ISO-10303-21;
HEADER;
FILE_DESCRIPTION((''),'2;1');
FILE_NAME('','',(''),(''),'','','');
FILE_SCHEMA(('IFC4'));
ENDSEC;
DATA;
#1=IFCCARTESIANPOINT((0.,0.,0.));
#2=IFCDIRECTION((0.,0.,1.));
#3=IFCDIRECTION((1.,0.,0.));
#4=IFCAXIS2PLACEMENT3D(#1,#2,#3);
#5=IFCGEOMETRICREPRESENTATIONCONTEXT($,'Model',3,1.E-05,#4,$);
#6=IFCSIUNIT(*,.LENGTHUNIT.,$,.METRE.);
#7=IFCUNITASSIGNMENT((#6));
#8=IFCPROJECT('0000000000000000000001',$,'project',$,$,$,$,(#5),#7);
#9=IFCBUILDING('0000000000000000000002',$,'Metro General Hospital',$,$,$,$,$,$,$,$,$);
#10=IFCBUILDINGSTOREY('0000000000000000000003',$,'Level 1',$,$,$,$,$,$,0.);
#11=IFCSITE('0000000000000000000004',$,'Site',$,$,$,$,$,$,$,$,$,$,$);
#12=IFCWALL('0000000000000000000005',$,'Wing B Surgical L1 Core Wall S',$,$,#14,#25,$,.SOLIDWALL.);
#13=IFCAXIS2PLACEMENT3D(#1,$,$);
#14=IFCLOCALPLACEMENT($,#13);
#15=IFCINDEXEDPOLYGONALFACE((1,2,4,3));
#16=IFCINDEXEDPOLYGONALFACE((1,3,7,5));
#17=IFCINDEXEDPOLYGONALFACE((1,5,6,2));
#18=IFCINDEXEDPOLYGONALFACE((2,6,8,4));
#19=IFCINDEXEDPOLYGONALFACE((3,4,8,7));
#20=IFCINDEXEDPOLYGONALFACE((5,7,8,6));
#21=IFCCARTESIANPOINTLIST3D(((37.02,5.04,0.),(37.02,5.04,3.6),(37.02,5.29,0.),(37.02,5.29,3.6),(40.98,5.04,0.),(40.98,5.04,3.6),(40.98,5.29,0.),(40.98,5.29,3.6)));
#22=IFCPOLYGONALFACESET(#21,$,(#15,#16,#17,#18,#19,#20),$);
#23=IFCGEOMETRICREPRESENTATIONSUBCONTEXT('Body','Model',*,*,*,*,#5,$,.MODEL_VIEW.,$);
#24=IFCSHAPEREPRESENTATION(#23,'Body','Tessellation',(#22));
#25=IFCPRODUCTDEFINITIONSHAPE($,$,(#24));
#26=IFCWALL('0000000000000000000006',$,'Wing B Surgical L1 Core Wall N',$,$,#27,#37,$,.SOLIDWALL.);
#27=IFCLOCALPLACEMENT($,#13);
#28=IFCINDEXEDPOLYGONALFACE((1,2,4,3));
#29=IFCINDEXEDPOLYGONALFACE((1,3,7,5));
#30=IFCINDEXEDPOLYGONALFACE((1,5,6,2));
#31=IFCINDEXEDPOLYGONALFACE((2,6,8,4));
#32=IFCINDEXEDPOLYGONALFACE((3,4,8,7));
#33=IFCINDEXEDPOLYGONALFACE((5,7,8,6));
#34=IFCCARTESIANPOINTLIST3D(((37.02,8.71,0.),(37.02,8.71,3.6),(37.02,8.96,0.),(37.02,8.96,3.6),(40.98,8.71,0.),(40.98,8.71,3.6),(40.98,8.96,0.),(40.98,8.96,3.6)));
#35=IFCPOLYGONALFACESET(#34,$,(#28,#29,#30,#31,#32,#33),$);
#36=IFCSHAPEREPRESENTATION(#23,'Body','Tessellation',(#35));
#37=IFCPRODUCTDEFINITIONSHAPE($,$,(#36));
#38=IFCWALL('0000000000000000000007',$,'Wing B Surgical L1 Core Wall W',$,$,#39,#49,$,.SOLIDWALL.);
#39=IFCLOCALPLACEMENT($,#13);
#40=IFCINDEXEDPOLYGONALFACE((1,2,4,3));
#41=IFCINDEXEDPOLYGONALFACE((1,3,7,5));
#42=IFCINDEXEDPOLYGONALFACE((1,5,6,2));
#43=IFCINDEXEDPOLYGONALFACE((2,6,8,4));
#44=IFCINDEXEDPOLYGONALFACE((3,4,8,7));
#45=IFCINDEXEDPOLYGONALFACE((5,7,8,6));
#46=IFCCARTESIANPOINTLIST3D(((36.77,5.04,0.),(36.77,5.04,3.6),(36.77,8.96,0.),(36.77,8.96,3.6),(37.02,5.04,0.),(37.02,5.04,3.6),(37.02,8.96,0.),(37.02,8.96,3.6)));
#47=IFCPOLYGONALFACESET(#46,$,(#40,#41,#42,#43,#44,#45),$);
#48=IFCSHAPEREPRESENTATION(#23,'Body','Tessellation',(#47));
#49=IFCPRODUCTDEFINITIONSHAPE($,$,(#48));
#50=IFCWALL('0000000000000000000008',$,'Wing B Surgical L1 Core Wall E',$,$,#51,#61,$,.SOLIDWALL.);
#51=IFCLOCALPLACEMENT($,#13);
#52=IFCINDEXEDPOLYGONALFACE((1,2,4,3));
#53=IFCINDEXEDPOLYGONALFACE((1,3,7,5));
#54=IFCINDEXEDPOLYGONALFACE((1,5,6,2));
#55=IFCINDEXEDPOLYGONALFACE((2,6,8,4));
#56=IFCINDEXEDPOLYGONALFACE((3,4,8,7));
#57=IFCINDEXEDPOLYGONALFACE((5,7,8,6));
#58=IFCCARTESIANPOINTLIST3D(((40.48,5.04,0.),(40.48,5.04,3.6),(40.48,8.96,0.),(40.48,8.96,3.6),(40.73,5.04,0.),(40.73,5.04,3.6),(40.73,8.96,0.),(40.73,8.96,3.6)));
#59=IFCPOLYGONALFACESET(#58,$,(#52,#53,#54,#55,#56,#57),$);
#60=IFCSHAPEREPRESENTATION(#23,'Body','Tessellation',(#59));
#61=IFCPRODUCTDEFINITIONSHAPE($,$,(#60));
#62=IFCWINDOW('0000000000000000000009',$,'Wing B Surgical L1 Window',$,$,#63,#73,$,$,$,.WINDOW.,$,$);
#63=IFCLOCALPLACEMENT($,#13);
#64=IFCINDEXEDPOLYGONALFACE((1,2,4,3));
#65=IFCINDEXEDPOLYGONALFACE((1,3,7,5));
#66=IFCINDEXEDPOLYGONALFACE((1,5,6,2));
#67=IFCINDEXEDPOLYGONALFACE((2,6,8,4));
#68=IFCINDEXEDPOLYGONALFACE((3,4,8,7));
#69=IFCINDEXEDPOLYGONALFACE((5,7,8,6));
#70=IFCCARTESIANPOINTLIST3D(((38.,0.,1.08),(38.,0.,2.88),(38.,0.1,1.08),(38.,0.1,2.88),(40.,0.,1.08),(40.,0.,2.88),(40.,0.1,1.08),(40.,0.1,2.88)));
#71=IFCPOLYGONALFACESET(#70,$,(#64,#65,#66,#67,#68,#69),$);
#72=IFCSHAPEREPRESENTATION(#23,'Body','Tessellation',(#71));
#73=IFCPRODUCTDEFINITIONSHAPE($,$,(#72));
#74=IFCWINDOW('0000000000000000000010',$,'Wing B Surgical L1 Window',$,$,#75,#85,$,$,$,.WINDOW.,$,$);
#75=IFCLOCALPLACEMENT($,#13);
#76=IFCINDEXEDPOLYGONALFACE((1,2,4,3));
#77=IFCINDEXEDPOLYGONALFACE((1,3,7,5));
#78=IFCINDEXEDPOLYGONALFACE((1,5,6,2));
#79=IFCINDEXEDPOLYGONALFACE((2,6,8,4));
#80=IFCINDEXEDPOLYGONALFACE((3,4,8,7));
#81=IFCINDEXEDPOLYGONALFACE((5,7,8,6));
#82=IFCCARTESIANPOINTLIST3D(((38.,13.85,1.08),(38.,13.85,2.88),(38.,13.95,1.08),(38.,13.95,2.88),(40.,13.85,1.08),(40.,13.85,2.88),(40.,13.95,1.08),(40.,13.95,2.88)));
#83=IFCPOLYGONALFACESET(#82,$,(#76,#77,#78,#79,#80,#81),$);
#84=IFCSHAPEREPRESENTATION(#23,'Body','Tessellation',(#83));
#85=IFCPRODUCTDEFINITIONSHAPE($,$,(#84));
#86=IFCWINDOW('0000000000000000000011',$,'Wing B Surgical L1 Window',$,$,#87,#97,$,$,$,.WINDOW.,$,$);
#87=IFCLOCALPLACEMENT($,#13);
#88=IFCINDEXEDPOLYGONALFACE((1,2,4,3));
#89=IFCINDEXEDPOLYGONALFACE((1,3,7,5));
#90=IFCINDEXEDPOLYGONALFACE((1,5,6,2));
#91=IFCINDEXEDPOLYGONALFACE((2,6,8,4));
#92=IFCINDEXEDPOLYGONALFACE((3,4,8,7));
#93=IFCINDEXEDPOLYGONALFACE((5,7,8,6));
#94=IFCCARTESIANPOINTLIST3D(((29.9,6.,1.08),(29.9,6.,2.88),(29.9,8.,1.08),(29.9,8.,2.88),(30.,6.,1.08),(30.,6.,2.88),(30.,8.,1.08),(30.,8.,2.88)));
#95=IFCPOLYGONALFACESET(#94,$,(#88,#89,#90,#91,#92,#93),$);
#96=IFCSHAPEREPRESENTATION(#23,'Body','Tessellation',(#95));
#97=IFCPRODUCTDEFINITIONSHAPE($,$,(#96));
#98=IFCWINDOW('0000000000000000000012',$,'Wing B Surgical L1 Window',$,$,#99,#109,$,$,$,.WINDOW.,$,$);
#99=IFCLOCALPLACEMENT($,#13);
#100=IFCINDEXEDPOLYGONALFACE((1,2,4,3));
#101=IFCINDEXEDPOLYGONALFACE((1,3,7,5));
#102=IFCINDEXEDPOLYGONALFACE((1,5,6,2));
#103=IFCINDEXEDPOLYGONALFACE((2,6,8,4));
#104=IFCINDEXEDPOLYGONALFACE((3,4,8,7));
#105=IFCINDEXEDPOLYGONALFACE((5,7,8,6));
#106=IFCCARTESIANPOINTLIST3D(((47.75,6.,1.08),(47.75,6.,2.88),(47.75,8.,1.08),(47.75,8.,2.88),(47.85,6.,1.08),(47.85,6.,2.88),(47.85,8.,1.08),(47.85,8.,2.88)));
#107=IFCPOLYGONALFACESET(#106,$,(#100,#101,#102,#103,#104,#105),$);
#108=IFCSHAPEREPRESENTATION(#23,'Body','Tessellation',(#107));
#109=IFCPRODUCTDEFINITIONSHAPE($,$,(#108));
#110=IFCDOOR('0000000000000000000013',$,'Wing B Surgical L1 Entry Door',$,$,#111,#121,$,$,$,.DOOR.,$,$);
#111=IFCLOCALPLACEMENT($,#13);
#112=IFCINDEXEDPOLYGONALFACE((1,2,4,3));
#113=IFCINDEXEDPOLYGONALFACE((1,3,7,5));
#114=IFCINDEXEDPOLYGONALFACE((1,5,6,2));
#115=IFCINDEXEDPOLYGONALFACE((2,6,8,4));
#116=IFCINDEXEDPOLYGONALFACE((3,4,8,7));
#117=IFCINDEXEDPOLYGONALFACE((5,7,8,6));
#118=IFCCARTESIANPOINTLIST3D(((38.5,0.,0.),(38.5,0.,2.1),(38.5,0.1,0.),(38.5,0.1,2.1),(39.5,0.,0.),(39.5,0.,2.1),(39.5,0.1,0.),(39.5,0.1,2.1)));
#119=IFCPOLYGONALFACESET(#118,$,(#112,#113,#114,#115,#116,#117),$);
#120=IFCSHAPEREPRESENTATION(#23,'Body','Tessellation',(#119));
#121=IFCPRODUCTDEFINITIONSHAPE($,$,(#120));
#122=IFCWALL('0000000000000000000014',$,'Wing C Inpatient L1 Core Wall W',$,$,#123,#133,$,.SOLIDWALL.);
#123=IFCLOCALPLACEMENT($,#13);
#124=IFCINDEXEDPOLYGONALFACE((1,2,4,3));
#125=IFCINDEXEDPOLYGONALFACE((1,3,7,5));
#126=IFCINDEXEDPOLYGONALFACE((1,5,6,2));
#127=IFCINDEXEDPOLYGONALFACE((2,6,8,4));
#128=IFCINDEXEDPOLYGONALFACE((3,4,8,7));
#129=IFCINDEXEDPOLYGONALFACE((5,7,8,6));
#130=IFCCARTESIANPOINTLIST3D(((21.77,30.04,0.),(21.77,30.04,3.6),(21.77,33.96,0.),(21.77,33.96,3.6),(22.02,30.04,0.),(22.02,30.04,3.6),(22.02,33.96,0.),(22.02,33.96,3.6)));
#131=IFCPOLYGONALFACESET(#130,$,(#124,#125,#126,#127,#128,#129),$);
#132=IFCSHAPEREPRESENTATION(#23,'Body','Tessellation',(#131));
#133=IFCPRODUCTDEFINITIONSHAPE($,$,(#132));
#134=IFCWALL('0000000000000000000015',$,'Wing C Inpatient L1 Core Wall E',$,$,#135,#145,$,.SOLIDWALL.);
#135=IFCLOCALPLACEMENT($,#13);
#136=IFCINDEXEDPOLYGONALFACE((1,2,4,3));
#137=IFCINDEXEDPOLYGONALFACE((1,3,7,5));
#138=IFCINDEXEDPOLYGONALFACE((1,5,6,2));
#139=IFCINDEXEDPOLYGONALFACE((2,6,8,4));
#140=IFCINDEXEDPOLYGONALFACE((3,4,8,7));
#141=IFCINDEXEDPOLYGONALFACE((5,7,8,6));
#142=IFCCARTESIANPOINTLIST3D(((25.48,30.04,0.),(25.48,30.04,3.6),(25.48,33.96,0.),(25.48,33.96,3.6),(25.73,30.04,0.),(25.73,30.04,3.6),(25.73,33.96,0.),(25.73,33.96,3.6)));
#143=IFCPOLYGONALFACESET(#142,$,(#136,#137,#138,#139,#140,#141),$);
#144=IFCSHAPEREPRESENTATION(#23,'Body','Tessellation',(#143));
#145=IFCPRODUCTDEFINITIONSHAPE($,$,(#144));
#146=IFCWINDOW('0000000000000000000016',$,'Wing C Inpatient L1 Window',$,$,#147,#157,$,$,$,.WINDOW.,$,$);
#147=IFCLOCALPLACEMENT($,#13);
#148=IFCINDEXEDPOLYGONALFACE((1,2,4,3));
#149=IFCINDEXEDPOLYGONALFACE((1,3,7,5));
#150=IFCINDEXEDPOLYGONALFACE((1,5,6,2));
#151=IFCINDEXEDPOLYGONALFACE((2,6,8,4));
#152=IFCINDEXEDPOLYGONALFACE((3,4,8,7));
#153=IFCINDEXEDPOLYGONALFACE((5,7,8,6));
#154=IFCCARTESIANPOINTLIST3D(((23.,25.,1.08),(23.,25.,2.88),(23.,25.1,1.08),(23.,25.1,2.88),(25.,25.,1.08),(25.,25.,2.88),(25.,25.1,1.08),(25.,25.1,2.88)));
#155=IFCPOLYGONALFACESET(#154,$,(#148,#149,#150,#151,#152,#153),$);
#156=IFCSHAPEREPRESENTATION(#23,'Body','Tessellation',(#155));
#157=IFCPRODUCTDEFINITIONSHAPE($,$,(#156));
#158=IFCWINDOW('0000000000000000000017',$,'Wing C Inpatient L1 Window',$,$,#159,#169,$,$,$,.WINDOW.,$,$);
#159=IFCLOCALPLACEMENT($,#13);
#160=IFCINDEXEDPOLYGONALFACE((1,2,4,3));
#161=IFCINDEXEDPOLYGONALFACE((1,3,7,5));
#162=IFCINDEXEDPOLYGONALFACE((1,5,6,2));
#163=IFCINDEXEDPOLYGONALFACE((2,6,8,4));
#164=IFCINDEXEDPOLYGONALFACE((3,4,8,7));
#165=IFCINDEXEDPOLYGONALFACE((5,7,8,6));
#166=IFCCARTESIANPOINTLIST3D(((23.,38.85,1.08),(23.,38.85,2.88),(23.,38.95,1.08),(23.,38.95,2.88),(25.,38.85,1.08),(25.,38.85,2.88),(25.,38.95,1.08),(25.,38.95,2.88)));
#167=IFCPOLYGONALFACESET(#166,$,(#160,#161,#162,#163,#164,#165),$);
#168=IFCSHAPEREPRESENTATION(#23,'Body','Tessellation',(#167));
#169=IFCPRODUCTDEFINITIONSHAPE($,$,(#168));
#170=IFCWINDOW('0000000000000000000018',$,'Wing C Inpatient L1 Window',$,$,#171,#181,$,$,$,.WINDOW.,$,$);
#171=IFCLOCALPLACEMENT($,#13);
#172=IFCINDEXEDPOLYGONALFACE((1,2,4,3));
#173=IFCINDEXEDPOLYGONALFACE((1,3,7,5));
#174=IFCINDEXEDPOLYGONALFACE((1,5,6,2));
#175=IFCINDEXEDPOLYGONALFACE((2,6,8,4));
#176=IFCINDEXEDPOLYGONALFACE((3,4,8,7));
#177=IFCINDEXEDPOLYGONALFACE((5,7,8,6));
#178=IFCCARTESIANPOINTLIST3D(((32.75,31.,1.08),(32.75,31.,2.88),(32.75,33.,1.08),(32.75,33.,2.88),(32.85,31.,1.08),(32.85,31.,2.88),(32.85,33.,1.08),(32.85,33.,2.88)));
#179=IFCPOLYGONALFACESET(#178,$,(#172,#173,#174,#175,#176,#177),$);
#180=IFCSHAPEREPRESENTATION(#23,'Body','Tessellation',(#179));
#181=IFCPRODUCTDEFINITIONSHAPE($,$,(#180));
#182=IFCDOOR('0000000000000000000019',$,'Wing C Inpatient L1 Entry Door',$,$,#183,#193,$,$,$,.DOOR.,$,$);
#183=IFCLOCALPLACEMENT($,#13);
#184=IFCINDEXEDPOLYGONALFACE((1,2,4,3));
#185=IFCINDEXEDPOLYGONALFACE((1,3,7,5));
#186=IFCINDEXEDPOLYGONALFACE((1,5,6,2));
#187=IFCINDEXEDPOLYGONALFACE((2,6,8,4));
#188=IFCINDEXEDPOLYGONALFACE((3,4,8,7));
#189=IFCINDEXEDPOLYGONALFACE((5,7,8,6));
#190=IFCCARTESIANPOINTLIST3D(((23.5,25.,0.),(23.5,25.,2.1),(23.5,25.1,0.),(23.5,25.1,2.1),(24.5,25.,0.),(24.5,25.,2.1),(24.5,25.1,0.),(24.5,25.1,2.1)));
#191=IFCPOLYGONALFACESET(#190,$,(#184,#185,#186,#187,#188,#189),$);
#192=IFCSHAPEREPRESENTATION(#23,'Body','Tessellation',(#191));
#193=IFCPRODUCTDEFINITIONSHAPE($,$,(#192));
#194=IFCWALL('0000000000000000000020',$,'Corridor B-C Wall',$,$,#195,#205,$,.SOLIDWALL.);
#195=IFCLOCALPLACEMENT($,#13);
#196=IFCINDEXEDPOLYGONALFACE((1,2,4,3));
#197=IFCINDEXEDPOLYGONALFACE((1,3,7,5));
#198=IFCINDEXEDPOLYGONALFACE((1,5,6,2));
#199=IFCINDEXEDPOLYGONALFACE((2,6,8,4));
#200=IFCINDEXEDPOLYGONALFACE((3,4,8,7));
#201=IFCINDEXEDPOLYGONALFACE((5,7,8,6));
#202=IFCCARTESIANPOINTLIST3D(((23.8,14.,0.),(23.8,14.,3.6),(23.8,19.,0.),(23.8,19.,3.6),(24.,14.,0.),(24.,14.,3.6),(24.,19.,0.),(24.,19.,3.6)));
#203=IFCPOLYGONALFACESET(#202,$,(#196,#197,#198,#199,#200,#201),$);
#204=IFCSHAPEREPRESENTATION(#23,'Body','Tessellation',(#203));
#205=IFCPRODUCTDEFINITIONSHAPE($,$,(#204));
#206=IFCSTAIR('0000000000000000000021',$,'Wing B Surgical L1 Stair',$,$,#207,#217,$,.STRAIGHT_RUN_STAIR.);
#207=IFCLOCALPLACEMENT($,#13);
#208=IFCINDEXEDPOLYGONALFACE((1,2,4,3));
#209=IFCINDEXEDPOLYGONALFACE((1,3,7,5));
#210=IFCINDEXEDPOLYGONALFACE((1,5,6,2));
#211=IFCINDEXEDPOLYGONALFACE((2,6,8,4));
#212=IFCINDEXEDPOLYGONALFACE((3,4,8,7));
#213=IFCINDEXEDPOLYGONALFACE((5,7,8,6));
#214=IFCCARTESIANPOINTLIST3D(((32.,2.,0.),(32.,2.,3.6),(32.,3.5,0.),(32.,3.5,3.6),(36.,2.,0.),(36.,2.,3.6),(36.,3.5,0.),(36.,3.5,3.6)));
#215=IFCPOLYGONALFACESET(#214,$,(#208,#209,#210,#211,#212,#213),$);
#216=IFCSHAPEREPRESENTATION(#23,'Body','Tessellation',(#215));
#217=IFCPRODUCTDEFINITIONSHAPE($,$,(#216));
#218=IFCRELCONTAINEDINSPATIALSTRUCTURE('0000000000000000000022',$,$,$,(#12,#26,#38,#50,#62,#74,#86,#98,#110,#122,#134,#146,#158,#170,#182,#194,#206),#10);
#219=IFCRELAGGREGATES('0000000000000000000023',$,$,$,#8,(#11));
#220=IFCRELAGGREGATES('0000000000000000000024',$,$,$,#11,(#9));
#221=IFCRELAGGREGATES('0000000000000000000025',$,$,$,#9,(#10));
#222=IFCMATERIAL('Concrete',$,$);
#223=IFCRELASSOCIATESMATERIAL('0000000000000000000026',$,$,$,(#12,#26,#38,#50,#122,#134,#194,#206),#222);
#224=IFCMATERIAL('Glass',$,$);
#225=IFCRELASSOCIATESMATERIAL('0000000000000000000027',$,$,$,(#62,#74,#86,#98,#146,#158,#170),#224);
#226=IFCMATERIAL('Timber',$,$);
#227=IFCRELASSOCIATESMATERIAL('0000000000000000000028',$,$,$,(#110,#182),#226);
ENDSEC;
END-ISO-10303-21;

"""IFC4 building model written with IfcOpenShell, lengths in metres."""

from ifc_helpers import new_model, si_unit, frame, origin_with_axes, place, context, subcontext, project, spatial, line, indexed_curve, outline, extrude, material, element, save


model = new_model("IFC4")

# Units and contexts
model_context = context("Model", 3, precision=1e-05, world=origin_with_axes())
body_context = subcontext(model_context, "Body", "Model", "MODEL_VIEW")
ifc_project = project(units=[si_unit("LENGTHUNIT", "METRE")], contexts=[model_context])

# Site, building, storey
site = spatial("IfcSite", under=ifc_project, Name="Site")
building = spatial("IfcBuilding", under=site, Name="Metro General Hospital")
storey = spatial("IfcBuildingStorey", under=building, Name="Level 1", Elevation=0.0)

# Shared definitions
ifc_material_1 = material(Name="Concrete")

# Walls
for number, where, z_axis, x_axis, name in (
    (1, (37.02, 5.04, 0.0), (0.0, 0.0, 1.0), (1.0, 0.0, 0.0), "Wing B Surgical L1 Core Wall S"),
    (2, (37.02, 8.71, 0.0), (0.0, 0.0, 1.0), (1.0, 0.0, 0.0), "Wing B Surgical L1 Core Wall N"),
):
    element("IfcWall", number, at=place(None, frame(where, z_axis=z_axis, x_axis=x_axis)), inside=storey, material=ifc_material_1, Name=name, PredefinedType="SOLIDWALL", context=body_context, shape_type="SweptSolid", body=[
        extrude(outline(indexed_curve([(0.0, 0.0), (3.96, 0.0), (3.96, 0.25), (0.0, 0.25)], segments=[line(1, 2, 3, 4, 1)])), origin_with_axes(), (0.0, 0.0, 1.0), 3.6),
    ])
for number, where, z_axis, x_axis, name in (
    (3, (37.02, 5.04, 0.0), (0.0, 0.0, 1.0), (0.0, 1.0, 0.0), "Wing B Surgical L1 Core Wall W"),
    (4, (40.73, 5.04, 0.0), (0.0, 0.0, 1.0), (0.0, 1.0, 0.0), "Wing B Surgical L1 Core Wall E"),
):
    element("IfcWall", number, at=place(None, frame(where, z_axis=z_axis, x_axis=x_axis)), inside=storey, material=ifc_material_1, Name=name, PredefinedType="SOLIDWALL", context=body_context, shape_type="SweptSolid", body=[
        extrude(outline(indexed_curve([(0.0, 0.0), (3.92, 0.0), (3.92, 0.25), (0.0, 0.25)], segments=[line(1, 2, 3, 4, 1)])), origin_with_axes(), (0.0, 0.0, 1.0), 3.6),
    ])

# Windows
ifc_material_2 = material(Name="Glass")
for number, where, z_axis, x_axis, name in (
    (5, (38.0, 0.0, 1.08), (0.0, 0.0, 1.0), (1.0, 0.0, 0.0), "Wing B Surgical L1 Window"),
    (6, (38.0, 13.85, 1.08), (0.0, 0.0, 1.0), (1.0, 0.0, 0.0), "Wing B Surgical L1 Window"),
    (7, (30.0, 6.0, 1.08), (0.0, 0.0, 1.0), (0.0, 1.0, 0.0), "Wing B Surgical L1 Window"),
    (8, (47.85, 6.0, 1.08), (0.0, 0.0, 1.0), (0.0, 1.0, 0.0), "Wing B Surgical L1 Window"),
):
    element("IfcWindow", number, at=place(None, frame(where, z_axis=z_axis, x_axis=x_axis)), inside=storey, material=ifc_material_2, Name=name, PredefinedType="WINDOW", context=body_context, shape_type="SweptSolid", body=[
        extrude(outline(indexed_curve([(0.0, 0.0), (2.0, 0.0), (2.0, 0.1), (0.0, 0.1)], segments=[line(1, 2, 3, 4, 1)])), origin_with_axes(), (0.0, 0.0, 1.0), 1.8),
    ])

# Door
ifc_material_3 = material(Name="Timber")
door_1_placement = place(None, frame((38.5, 0.0, 0.0), z_axis=(0.0, 0.0, 1.0), x_axis=(1.0, 0.0, 0.0)))
element("IfcDoor", 9, at=door_1_placement, inside=storey, material=ifc_material_3, Name="Wing B Surgical L1 Entry Door", PredefinedType="DOOR", context=body_context, shape_type="SweptSolid", body=[
    extrude(outline(indexed_curve([(0.0, 0.0), (1.0, 0.0), (1.0, 0.1), (0.0, 0.1)], segments=[line(1, 2, 3, 4, 1)])), origin_with_axes(), (0.0, 0.0, 1.0), 2.1),
])

# Walls
for number, where, z_axis, x_axis, name in (
    (10, (22.02, 30.04, 0.0), (0.0, 0.0, 1.0), (0.0, 1.0, 0.0), "Wing C Inpatient L1 Core Wall W"),
    (11, (25.73, 30.04, 0.0), (0.0, 0.0, 1.0), (0.0, 1.0, 0.0), "Wing C Inpatient L1 Core Wall E"),
):
    element("IfcWall", number, at=place(None, frame(where, z_axis=z_axis, x_axis=x_axis)), inside=storey, material=ifc_material_1, Name=name, PredefinedType="SOLIDWALL", context=body_context, shape_type="SweptSolid", body=[
        extrude(outline(indexed_curve([(0.0, 0.0), (3.92, 0.0), (3.92, 0.25), (0.0, 0.25)], segments=[line(1, 2, 3, 4, 1)])), origin_with_axes(), (0.0, 0.0, 1.0), 3.6),
    ])

# Windows
for number, where, z_axis, x_axis, name in (
    (12, (23.0, 25.0, 1.08), (0.0, 0.0, 1.0), (1.0, 0.0, 0.0), "Wing C Inpatient L1 Window"),
    (13, (23.0, 38.85, 1.08), (0.0, 0.0, 1.0), (1.0, 0.0, 0.0), "Wing C Inpatient L1 Window"),
    (14, (32.85, 31.0, 1.08), (0.0, 0.0, 1.0), (0.0, 1.0, 0.0), "Wing C Inpatient L1 Window"),
):
    element("IfcWindow", number, at=place(None, frame(where, z_axis=z_axis, x_axis=x_axis)), inside=storey, material=ifc_material_2, Name=name, PredefinedType="WINDOW", context=body_context, shape_type="SweptSolid", body=[
        extrude(outline(indexed_curve([(0.0, 0.0), (2.0, 0.0), (2.0, 0.1), (0.0, 0.1)], segments=[line(1, 2, 3, 4, 1)])), origin_with_axes(), (0.0, 0.0, 1.0), 1.8),
    ])

# Door
door_2_placement = place(None, frame((23.5, 25.0, 0.0), z_axis=(0.0, 0.0, 1.0), x_axis=(1.0, 0.0, 0.0)))
element("IfcDoor", 15, at=door_2_placement, inside=storey, material=ifc_material_3, Name="Wing C Inpatient L1 Entry Door", PredefinedType="DOOR", context=body_context, shape_type="SweptSolid", body=[
    extrude(outline(indexed_curve([(0.0, 0.0), (1.0, 0.0), (1.0, 0.1), (0.0, 0.1)], segments=[line(1, 2, 3, 4, 1)])), origin_with_axes(), (0.0, 0.0, 1.0), 2.1),
])

# Wall
wall_placement = place(None, frame((24.0, 14.0, 0.0), z_axis=(0.0, 0.0, 1.0), x_axis=(0.0, 1.0, 0.0)))
element("IfcWall", 16, at=wall_placement, inside=storey, material=ifc_material_1, Name="Corridor B-C Wall", PredefinedType="SOLIDWALL", context=body_context, shape_type="SweptSolid", body=[
    extrude(outline(indexed_curve([(0.0, 0.0), (5.0, 0.0), (5.0, 0.2), (0.0, 0.2)], segments=[line(1, 2, 3, 4, 1)])), origin_with_axes(), (0.0, 0.0, 1.0), 3.6),
])

# Stair
stair_placement = place(None, frame((32.0, 2.0, 0.0), z_axis=(0.0, 0.0, 1.0), x_axis=(1.0, 0.0, 0.0)))
element("IfcStair", 17, at=stair_placement, inside=storey, material=ifc_material_1, Name="Wing B Surgical L1 Stair", PredefinedType="STRAIGHT_RUN_STAIR", context=body_context, shape_type="SweptSolid", body=[
    extrude(outline(indexed_curve([(0.0, 0.0), (4.0, 0.0), (4.0, 1.5), (0.0, 1.5)], segments=[line(1, 2, 3, 4, 1)])), origin_with_axes(), (0.0, 0.0, 1.0), 3.6),
])

save(model, "model.ifc")
